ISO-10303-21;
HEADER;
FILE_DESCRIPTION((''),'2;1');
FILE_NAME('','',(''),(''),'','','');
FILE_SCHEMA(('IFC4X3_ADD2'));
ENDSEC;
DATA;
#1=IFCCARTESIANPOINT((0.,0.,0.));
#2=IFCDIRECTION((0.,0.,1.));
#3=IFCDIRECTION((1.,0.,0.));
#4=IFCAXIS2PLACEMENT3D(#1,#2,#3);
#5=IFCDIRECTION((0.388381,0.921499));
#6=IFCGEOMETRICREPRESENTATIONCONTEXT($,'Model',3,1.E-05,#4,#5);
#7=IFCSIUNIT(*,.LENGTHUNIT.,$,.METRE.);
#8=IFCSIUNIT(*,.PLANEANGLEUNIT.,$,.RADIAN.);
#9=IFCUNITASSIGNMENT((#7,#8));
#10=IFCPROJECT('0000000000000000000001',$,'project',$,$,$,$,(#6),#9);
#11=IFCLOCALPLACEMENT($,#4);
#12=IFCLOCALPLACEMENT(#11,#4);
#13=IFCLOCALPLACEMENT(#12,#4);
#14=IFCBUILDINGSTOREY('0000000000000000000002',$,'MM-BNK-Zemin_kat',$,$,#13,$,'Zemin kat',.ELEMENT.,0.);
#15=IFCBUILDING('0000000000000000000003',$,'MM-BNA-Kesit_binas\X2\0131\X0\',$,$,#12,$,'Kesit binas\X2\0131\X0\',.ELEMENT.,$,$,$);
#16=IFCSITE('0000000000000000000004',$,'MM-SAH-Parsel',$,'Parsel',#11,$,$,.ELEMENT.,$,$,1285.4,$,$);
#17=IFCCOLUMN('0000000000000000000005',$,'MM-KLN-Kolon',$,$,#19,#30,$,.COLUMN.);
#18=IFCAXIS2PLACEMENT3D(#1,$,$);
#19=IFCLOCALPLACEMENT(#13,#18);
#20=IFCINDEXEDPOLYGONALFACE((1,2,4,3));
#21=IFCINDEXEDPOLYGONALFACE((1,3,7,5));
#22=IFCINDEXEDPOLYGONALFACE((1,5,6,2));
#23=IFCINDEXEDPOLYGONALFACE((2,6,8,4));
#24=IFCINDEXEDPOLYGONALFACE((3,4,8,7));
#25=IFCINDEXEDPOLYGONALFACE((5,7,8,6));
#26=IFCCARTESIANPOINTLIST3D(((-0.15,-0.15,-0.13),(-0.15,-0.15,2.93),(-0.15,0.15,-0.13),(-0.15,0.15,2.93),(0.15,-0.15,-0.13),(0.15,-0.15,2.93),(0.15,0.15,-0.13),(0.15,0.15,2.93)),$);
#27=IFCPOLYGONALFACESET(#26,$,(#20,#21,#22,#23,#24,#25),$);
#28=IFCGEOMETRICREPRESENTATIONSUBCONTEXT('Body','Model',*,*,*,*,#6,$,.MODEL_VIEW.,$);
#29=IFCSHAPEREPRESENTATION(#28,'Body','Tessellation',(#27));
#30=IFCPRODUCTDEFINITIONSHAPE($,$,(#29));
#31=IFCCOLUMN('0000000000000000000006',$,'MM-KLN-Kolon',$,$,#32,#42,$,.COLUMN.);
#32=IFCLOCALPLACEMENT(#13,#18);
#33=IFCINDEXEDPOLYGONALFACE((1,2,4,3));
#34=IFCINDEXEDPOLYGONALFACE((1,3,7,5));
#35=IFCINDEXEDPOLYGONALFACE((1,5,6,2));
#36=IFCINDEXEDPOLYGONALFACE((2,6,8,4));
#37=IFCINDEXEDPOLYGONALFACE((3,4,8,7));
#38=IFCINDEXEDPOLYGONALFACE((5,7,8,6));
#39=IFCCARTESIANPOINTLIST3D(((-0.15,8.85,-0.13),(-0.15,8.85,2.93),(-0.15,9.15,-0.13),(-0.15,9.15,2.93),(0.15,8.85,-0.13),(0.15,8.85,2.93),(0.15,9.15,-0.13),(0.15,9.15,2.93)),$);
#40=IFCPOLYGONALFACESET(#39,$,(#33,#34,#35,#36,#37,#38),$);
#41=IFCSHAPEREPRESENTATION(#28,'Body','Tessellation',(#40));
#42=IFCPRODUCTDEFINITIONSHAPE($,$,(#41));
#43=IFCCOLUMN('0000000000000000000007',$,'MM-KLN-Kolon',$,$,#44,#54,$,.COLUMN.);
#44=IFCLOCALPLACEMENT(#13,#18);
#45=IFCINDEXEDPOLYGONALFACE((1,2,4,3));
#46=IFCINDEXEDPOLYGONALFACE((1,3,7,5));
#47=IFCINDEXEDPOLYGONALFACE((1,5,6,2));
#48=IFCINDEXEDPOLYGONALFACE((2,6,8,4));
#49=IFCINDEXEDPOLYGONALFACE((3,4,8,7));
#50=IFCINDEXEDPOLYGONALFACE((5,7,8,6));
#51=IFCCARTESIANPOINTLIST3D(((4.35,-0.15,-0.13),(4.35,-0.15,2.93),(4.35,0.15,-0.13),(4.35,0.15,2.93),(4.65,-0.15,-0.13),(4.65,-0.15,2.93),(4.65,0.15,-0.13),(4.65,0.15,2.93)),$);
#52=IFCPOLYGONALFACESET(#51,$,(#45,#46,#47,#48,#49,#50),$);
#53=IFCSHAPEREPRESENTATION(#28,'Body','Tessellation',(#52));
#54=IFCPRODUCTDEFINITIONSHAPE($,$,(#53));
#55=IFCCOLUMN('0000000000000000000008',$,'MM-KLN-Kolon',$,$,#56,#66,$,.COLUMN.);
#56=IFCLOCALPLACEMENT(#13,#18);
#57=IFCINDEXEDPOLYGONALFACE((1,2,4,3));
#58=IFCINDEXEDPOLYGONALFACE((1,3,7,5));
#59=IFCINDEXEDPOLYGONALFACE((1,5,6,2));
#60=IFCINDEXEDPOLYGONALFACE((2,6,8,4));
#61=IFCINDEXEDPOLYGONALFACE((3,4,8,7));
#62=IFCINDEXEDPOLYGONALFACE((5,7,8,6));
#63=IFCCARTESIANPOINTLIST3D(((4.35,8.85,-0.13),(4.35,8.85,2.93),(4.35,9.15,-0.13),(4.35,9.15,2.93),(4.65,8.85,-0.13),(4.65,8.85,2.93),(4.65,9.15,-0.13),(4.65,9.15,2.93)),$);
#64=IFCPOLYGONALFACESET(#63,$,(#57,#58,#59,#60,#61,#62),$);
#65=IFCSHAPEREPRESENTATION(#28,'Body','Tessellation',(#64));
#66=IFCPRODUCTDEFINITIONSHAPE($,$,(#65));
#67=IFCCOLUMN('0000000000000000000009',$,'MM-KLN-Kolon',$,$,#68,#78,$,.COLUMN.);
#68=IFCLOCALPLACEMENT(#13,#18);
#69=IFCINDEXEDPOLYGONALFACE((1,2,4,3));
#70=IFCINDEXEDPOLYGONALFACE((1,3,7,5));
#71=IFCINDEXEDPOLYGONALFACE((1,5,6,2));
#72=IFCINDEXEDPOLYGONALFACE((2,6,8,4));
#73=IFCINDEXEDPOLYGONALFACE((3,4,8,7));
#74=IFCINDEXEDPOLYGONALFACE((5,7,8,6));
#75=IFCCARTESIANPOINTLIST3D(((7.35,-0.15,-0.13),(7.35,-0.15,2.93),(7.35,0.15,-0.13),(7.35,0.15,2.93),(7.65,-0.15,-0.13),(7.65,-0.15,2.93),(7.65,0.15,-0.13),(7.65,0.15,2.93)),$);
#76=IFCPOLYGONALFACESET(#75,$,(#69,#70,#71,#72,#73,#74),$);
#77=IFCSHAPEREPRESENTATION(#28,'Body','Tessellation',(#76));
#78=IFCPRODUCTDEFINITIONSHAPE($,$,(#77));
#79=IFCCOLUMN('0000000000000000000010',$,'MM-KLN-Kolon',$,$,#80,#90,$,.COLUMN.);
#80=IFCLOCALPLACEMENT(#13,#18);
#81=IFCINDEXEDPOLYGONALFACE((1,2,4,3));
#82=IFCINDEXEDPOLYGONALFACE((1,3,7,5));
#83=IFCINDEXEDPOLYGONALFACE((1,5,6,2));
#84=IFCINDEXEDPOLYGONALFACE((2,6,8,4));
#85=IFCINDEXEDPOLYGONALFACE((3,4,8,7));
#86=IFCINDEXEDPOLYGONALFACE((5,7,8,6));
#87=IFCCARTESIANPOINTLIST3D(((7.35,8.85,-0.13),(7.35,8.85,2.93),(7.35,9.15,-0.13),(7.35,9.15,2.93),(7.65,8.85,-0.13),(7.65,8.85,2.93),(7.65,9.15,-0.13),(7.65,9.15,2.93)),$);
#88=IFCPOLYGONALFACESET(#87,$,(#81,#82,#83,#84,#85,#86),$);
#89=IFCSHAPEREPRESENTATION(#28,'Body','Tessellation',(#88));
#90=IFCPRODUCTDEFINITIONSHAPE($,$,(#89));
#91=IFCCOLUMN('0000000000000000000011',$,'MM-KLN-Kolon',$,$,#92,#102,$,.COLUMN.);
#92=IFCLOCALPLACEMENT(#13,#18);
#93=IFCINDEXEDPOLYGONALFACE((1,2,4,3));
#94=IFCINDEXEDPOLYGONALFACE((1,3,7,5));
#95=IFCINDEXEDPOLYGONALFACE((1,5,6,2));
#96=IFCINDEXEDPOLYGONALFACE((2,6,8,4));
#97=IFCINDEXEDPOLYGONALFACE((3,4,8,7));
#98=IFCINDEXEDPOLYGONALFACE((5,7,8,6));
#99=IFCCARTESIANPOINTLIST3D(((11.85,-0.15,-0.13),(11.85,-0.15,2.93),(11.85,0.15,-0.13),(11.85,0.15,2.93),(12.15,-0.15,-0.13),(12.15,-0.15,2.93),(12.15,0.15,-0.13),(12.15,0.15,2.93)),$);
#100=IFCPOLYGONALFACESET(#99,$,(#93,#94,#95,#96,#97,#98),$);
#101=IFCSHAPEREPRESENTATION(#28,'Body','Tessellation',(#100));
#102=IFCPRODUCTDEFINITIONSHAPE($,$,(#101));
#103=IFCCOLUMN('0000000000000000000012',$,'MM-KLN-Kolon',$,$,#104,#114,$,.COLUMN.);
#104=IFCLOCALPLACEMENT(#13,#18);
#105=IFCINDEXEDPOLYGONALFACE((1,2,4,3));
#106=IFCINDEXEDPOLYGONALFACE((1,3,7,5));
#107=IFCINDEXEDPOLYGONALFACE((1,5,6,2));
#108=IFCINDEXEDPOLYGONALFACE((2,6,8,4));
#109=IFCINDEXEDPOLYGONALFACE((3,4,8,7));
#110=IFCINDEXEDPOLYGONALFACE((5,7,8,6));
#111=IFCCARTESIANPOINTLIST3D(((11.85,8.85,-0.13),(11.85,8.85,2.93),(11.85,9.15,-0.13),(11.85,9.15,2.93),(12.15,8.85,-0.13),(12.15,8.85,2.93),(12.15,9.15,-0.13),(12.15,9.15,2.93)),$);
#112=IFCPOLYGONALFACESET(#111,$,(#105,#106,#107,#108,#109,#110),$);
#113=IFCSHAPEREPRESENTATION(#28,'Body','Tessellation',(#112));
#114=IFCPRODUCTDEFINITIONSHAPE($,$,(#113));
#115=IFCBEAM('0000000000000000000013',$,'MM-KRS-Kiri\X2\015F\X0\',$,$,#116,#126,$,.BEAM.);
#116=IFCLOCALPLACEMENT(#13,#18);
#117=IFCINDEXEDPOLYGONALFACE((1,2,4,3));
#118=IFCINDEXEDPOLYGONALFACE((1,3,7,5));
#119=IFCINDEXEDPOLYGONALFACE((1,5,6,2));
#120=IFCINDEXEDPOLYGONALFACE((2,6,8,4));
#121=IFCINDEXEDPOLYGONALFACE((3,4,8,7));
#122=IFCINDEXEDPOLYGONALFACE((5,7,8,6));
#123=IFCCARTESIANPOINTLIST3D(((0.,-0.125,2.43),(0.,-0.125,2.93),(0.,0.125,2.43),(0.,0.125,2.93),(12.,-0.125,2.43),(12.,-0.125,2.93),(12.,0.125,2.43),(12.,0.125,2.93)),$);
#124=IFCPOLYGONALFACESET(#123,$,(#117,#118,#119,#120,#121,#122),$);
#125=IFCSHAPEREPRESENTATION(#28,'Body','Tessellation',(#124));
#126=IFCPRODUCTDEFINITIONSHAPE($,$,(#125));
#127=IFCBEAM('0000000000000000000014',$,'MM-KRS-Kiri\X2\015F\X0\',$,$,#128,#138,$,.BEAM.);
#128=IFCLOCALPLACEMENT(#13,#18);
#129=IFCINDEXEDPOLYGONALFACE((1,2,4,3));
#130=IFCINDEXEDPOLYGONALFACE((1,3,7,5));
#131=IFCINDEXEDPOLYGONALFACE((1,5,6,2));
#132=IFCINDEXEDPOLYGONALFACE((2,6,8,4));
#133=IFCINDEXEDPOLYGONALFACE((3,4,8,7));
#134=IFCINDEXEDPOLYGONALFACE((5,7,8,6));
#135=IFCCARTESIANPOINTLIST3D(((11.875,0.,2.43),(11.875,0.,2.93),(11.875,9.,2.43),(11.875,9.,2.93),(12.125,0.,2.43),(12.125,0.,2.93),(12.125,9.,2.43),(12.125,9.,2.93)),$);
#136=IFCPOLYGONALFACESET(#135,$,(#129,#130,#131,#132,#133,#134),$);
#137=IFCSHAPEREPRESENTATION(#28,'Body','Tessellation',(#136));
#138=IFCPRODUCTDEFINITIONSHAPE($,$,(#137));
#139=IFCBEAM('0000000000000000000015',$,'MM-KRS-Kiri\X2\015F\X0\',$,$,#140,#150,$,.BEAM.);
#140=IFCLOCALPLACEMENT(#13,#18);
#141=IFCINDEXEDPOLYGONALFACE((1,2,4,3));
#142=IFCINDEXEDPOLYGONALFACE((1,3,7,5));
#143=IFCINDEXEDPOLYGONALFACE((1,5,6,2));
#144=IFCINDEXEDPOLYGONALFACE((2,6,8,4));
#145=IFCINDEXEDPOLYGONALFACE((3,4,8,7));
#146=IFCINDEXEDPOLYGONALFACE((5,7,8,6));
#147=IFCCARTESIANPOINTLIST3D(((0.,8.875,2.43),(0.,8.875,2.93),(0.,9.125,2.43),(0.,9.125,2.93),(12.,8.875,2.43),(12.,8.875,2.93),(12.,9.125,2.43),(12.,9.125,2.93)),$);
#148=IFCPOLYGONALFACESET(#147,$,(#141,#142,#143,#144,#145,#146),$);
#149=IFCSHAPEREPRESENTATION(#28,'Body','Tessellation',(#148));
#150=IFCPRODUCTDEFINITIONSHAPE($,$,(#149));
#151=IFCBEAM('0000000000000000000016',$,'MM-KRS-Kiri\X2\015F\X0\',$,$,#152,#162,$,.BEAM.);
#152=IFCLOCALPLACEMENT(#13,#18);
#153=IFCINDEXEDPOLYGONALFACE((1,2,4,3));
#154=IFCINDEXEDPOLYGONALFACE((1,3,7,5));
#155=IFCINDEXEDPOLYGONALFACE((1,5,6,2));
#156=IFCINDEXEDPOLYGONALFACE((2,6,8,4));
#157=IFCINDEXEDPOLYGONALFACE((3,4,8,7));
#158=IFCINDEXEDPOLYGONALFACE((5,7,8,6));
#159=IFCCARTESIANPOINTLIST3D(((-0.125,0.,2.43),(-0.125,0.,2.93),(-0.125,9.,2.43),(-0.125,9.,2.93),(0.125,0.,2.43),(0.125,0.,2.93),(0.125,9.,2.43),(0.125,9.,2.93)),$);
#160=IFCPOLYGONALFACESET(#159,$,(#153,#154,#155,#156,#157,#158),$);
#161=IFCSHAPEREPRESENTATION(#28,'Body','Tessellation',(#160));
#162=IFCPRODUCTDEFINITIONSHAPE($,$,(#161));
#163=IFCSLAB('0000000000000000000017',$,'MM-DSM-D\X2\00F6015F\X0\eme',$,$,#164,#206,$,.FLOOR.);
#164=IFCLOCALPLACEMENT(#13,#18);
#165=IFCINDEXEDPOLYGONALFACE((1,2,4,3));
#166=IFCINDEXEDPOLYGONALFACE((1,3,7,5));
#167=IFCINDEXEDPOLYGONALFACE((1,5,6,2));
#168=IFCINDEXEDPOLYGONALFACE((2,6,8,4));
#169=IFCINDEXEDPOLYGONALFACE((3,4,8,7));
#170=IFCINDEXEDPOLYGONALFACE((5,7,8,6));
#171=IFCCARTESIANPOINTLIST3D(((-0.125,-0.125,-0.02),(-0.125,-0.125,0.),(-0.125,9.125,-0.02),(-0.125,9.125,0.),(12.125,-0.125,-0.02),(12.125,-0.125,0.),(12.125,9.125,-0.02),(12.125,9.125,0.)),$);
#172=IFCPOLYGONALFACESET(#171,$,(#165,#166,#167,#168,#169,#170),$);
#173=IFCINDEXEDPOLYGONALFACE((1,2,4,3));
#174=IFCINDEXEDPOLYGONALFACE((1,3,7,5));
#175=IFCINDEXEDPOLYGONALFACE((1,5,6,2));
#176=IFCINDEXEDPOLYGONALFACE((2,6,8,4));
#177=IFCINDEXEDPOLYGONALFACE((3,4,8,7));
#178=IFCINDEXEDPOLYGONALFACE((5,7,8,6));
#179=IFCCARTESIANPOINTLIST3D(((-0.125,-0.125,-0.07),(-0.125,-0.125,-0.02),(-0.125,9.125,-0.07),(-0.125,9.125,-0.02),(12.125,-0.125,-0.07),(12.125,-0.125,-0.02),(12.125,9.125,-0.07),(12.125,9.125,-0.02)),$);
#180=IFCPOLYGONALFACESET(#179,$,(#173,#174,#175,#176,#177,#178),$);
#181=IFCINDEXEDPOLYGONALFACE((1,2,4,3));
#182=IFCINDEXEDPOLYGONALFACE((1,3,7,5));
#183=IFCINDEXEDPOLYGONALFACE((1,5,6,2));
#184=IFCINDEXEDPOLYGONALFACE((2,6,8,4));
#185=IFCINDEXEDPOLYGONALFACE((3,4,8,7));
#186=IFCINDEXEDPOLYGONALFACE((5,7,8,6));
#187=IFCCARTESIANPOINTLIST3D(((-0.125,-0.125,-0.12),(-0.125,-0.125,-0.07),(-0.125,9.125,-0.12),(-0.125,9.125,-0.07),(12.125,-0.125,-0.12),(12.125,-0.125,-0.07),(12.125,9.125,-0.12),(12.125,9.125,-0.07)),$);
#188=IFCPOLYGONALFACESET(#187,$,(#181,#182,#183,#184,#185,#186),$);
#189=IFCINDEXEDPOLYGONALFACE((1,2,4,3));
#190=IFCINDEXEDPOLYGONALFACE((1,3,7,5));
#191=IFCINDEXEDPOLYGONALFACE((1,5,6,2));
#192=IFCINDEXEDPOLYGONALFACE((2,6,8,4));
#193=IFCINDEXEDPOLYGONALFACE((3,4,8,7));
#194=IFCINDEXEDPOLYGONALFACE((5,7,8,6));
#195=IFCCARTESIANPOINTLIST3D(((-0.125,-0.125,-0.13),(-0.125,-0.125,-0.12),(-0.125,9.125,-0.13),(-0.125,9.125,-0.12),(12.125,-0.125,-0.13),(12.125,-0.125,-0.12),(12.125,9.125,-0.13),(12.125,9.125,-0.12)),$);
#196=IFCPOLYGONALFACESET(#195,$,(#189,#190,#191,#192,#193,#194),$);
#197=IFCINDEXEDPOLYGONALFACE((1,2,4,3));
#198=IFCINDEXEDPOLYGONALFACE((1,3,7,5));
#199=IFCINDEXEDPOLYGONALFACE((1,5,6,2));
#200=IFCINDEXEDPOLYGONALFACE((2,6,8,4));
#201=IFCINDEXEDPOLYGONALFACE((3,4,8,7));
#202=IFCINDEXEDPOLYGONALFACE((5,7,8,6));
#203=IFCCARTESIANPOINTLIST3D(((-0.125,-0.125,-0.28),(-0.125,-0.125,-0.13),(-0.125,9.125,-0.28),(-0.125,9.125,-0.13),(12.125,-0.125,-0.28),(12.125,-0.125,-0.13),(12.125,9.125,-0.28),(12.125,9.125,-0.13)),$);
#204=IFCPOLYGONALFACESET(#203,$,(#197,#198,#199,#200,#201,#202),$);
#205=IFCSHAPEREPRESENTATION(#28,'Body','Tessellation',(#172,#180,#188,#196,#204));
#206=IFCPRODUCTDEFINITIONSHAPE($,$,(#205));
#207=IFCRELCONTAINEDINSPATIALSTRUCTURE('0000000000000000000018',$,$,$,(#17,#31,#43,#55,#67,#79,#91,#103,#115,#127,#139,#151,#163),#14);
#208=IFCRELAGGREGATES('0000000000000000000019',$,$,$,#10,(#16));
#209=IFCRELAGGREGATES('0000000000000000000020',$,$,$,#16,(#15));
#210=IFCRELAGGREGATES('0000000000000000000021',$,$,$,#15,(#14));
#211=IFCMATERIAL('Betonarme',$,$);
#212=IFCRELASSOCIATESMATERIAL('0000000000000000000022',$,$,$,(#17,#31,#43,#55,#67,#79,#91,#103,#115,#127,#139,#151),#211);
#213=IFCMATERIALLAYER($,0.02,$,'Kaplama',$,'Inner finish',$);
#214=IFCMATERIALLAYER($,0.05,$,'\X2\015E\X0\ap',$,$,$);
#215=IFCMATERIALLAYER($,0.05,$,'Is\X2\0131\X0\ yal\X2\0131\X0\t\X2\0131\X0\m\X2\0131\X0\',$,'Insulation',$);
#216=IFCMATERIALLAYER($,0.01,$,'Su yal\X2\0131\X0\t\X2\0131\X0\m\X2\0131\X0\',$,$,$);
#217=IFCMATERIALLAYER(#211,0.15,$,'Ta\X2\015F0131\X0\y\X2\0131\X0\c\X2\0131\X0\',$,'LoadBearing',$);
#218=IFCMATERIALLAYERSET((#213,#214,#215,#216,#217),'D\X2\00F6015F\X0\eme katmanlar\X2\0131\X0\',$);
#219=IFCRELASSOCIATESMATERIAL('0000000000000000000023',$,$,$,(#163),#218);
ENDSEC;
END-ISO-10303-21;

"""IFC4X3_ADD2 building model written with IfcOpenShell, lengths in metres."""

from ifc_helpers import new_model, si_unit, direction, frame, origin_with_axes, place, context, subcontext, project, spatial, polyline, outline, extrude, material, layer, layer_set, layer_usage, element, save


model = new_model("IFC4X3_ADD2")

# Units and contexts
model_context = context("Model", 3, precision=1e-05, world=origin_with_axes(), true_north=direction((0.388381, 0.921499)))
body_context = subcontext(model_context, "Body", "Model", "MODEL_VIEW")
ifc_project = project(units=[si_unit("LENGTHUNIT", "METRE"), si_unit("PLANEANGLEUNIT", "RADIAN")], contexts=[model_context])

# Site, building, storey
site_placement = place(None, origin_with_axes())
site = spatial("IfcSite", under=ifc_project, at=site_placement, Name="MM-SAH-Parsel", ObjectType="Parsel", CompositionType="ELEMENT", RefElevation=1285.4)
building_placement = place(site_placement, origin_with_axes())
building = spatial("IfcBuilding", under=site, at=building_placement, Name="MM-BNA-Kesit_binası", LongName="Kesit binası", CompositionType="ELEMENT")
storey_placement = place(building_placement, origin_with_axes())
storey = spatial("IfcBuildingStorey", under=building, at=storey_placement, Name="MM-BNK-Zemin_kat", LongName="Zemin kat", CompositionType="ELEMENT", Elevation=0.0)

# Columns
ifc_material_1 = material(Name="Betonarme")
column_1_placement = place(storey_placement, origin_with_axes())
element("IfcColumn", 1, at=column_1_placement, inside=storey, material=ifc_material_1, Name="MM-KLN-Kolon", PredefinedType="COLUMN", context=body_context, shape_type="SweptSolid", body=[
    extrude(outline(polyline([(-0.15, -0.15), (0.15, -0.15), (0.15, 0.15), (-0.15, 0.15), (-0.15, -0.15)])), frame((0.0, 0.0, -0.13)), (0.0, 0.0, 1.0), 3.06),
])
column_2_placement = place(storey_placement, origin_with_axes())
element("IfcColumn", 2, at=column_2_placement, inside=storey, material=ifc_material_1, Name="MM-KLN-Kolon", PredefinedType="COLUMN", context=body_context, shape_type="SweptSolid", body=[
    extrude(outline(polyline([(-0.15, 8.85), (0.15, 8.85), (0.15, 9.15), (-0.15, 9.15), (-0.15, 8.85)])), frame((0.0, 0.0, -0.13)), (0.0, 0.0, 1.0), 3.06),
])
column_3_placement = place(storey_placement, origin_with_axes())
element("IfcColumn", 3, at=column_3_placement, inside=storey, material=ifc_material_1, Name="MM-KLN-Kolon", PredefinedType="COLUMN", context=body_context, shape_type="SweptSolid", body=[
    extrude(outline(polyline([(4.35, -0.15), (4.65, -0.15), (4.65, 0.15), (4.35, 0.15), (4.35, -0.15)])), frame((0.0, 0.0, -0.13)), (0.0, 0.0, 1.0), 3.06),
])
column_4_placement = place(storey_placement, origin_with_axes())
element("IfcColumn", 4, at=column_4_placement, inside=storey, material=ifc_material_1, Name="MM-KLN-Kolon", PredefinedType="COLUMN", context=body_context, shape_type="SweptSolid", body=[
    extrude(outline(polyline([(4.35, 8.85), (4.65, 8.85), (4.65, 9.15), (4.35, 9.15), (4.35, 8.85)])), frame((0.0, 0.0, -0.13)), (0.0, 0.0, 1.0), 3.06),
])
column_5_placement = place(storey_placement, origin_with_axes())
element("IfcColumn", 5, at=column_5_placement, inside=storey, material=ifc_material_1, Name="MM-KLN-Kolon", PredefinedType="COLUMN", context=body_context, shape_type="SweptSolid", body=[
    extrude(outline(polyline([(7.35, -0.15), (7.65, -0.15), (7.65, 0.15), (7.35, 0.15), (7.35, -0.15)])), frame((0.0, 0.0, -0.13)), (0.0, 0.0, 1.0), 3.06),
])
column_6_placement = place(storey_placement, origin_with_axes())
element("IfcColumn", 6, at=column_6_placement, inside=storey, material=ifc_material_1, Name="MM-KLN-Kolon", PredefinedType="COLUMN", context=body_context, shape_type="SweptSolid", body=[
    extrude(outline(polyline([(7.35, 8.85), (7.65, 8.85), (7.65, 9.15), (7.35, 9.15), (7.35, 8.85)])), frame((0.0, 0.0, -0.13)), (0.0, 0.0, 1.0), 3.06),
])
column_7_placement = place(storey_placement, origin_with_axes())
element("IfcColumn", 7, at=column_7_placement, inside=storey, material=ifc_material_1, Name="MM-KLN-Kolon", PredefinedType="COLUMN", context=body_context, shape_type="SweptSolid", body=[
    extrude(outline(polyline([(11.85, -0.15), (12.15, -0.15), (12.15, 0.15), (11.85, 0.15), (11.85, -0.15)])), frame((0.0, 0.0, -0.13)), (0.0, 0.0, 1.0), 3.06),
])
column_8_placement = place(storey_placement, origin_with_axes())
element("IfcColumn", 8, at=column_8_placement, inside=storey, material=ifc_material_1, Name="MM-KLN-Kolon", PredefinedType="COLUMN", context=body_context, shape_type="SweptSolid", body=[
    extrude(outline(polyline([(11.85, 8.85), (12.15, 8.85), (12.15, 9.15), (11.85, 9.15), (11.85, 8.85)])), frame((0.0, 0.0, -0.13)), (0.0, 0.0, 1.0), 3.06),
])

# Beams
beam_1_placement = place(storey_placement, origin_with_axes())
element("IfcBeam", 9, at=beam_1_placement, inside=storey, material=ifc_material_1, Name="MM-KRS-Kiriş", PredefinedType="BEAM", context=body_context, shape_type="SweptSolid", body=[
    extrude(outline(polyline([(0.0, 0.125), (12.0, 0.125), (12.0, -0.125), (0.0, -0.125), (0.0, 0.125)])), frame((0.0, 0.0, 2.43)), (0.0, 0.0, 1.0), 0.5),
])
beam_2_placement = place(storey_placement, origin_with_axes())
element("IfcBeam", 10, at=beam_2_placement, inside=storey, material=ifc_material_1, Name="MM-KRS-Kiriş", PredefinedType="BEAM", context=body_context, shape_type="SweptSolid", body=[
    extrude(outline(polyline([(11.875, 0.0), (11.875, 9.0), (12.125, 9.0), (12.125, 0.0), (11.875, 0.0)])), frame((0.0, 0.0, 2.43)), (0.0, 0.0, 1.0), 0.5),
])
beam_3_placement = place(storey_placement, origin_with_axes())
element("IfcBeam", 11, at=beam_3_placement, inside=storey, material=ifc_material_1, Name="MM-KRS-Kiriş", PredefinedType="BEAM", context=body_context, shape_type="SweptSolid", body=[
    extrude(outline(polyline([(12.0, 8.875), (0.0, 8.875), (0.0, 9.125), (12.0, 9.125), (12.0, 8.875)])), frame((0.0, 0.0, 2.43)), (0.0, 0.0, 1.0), 0.5),
])
beam_4_placement = place(storey_placement, origin_with_axes())
element("IfcBeam", 12, at=beam_4_placement, inside=storey, material=ifc_material_1, Name="MM-KRS-Kiriş", PredefinedType="BEAM", context=body_context, shape_type="SweptSolid", body=[
    extrude(outline(polyline([(0.125, 9.0), (0.125, 0.0), (-0.125, 0.0), (-0.125, 9.0), (0.125, 9.0)])), frame((0.0, 0.0, 2.43)), (0.0, 0.0, 1.0), 0.5),
])

# Slab
ifc_layer_1 = layer(None, 0.02, Name="Kaplama", Category="Inner finish")
ifc_layer_2 = layer(None, 0.05, Name="Şap")
ifc_layer_3 = layer(None, 0.05, Name="Isı yalıtımı", Category="Insulation")
ifc_layer_4 = layer(None, 0.01, Name="Su yalıtımı")
ifc_layer_5 = layer(ifc_material_1, 0.15, Name="Taşıyıcı", Category="LoadBearing")
ifc_layer_set_1 = layer_set([ifc_layer_1, ifc_layer_2, ifc_layer_3, ifc_layer_4, ifc_layer_5], Name="Döşeme katmanları")
ifc_layer_usage = layer_usage(ifc_layer_set_1, "AXIS3", "NEGATIVE", 0.0)
slab_placement = place(storey_placement, origin_with_axes())
element("IfcSlab", 13, at=slab_placement, inside=storey, material=ifc_layer_usage, Name="MM-DSM-Döşeme", PredefinedType="FLOOR", context=body_context, shape_type="SweptSolid", body=[
    extrude(outline(polyline([(-0.125, -0.125), (12.125, -0.125), (12.125, 9.125), (-0.125, 9.125), (-0.125, -0.125)])), frame((0.0, 0.0, -0.02)), (0.0, 0.0, 1.0), 0.02),
    extrude(outline(polyline([(-0.125, -0.125), (12.125, -0.125), (12.125, 9.125), (-0.125, 9.125), (-0.125, -0.125)])), frame((0.0, 0.0, -0.07)), (0.0, 0.0, 1.0), 0.05),
    extrude(outline(polyline([(-0.125, -0.125), (12.125, -0.125), (12.125, 9.125), (-0.125, 9.125), (-0.125, -0.125)])), frame((0.0, 0.0, -0.12)), (0.0, 0.0, 1.0), 0.05),
    extrude(outline(polyline([(-0.125, -0.125), (12.125, -0.125), (12.125, 9.125), (-0.125, 9.125), (-0.125, -0.125)])), frame((0.0, 0.0, -0.13)), (0.0, 0.0, 1.0), 0.01),
    extrude(outline(polyline([(-0.125, -0.125), (12.125, -0.125), (12.125, 9.125), (-0.125, 9.125), (-0.125, -0.125)])), frame((0.0, 0.0, -0.28)), (0.0, 0.0, 1.0), 0.15),
])

save(model, "model.ifc")
